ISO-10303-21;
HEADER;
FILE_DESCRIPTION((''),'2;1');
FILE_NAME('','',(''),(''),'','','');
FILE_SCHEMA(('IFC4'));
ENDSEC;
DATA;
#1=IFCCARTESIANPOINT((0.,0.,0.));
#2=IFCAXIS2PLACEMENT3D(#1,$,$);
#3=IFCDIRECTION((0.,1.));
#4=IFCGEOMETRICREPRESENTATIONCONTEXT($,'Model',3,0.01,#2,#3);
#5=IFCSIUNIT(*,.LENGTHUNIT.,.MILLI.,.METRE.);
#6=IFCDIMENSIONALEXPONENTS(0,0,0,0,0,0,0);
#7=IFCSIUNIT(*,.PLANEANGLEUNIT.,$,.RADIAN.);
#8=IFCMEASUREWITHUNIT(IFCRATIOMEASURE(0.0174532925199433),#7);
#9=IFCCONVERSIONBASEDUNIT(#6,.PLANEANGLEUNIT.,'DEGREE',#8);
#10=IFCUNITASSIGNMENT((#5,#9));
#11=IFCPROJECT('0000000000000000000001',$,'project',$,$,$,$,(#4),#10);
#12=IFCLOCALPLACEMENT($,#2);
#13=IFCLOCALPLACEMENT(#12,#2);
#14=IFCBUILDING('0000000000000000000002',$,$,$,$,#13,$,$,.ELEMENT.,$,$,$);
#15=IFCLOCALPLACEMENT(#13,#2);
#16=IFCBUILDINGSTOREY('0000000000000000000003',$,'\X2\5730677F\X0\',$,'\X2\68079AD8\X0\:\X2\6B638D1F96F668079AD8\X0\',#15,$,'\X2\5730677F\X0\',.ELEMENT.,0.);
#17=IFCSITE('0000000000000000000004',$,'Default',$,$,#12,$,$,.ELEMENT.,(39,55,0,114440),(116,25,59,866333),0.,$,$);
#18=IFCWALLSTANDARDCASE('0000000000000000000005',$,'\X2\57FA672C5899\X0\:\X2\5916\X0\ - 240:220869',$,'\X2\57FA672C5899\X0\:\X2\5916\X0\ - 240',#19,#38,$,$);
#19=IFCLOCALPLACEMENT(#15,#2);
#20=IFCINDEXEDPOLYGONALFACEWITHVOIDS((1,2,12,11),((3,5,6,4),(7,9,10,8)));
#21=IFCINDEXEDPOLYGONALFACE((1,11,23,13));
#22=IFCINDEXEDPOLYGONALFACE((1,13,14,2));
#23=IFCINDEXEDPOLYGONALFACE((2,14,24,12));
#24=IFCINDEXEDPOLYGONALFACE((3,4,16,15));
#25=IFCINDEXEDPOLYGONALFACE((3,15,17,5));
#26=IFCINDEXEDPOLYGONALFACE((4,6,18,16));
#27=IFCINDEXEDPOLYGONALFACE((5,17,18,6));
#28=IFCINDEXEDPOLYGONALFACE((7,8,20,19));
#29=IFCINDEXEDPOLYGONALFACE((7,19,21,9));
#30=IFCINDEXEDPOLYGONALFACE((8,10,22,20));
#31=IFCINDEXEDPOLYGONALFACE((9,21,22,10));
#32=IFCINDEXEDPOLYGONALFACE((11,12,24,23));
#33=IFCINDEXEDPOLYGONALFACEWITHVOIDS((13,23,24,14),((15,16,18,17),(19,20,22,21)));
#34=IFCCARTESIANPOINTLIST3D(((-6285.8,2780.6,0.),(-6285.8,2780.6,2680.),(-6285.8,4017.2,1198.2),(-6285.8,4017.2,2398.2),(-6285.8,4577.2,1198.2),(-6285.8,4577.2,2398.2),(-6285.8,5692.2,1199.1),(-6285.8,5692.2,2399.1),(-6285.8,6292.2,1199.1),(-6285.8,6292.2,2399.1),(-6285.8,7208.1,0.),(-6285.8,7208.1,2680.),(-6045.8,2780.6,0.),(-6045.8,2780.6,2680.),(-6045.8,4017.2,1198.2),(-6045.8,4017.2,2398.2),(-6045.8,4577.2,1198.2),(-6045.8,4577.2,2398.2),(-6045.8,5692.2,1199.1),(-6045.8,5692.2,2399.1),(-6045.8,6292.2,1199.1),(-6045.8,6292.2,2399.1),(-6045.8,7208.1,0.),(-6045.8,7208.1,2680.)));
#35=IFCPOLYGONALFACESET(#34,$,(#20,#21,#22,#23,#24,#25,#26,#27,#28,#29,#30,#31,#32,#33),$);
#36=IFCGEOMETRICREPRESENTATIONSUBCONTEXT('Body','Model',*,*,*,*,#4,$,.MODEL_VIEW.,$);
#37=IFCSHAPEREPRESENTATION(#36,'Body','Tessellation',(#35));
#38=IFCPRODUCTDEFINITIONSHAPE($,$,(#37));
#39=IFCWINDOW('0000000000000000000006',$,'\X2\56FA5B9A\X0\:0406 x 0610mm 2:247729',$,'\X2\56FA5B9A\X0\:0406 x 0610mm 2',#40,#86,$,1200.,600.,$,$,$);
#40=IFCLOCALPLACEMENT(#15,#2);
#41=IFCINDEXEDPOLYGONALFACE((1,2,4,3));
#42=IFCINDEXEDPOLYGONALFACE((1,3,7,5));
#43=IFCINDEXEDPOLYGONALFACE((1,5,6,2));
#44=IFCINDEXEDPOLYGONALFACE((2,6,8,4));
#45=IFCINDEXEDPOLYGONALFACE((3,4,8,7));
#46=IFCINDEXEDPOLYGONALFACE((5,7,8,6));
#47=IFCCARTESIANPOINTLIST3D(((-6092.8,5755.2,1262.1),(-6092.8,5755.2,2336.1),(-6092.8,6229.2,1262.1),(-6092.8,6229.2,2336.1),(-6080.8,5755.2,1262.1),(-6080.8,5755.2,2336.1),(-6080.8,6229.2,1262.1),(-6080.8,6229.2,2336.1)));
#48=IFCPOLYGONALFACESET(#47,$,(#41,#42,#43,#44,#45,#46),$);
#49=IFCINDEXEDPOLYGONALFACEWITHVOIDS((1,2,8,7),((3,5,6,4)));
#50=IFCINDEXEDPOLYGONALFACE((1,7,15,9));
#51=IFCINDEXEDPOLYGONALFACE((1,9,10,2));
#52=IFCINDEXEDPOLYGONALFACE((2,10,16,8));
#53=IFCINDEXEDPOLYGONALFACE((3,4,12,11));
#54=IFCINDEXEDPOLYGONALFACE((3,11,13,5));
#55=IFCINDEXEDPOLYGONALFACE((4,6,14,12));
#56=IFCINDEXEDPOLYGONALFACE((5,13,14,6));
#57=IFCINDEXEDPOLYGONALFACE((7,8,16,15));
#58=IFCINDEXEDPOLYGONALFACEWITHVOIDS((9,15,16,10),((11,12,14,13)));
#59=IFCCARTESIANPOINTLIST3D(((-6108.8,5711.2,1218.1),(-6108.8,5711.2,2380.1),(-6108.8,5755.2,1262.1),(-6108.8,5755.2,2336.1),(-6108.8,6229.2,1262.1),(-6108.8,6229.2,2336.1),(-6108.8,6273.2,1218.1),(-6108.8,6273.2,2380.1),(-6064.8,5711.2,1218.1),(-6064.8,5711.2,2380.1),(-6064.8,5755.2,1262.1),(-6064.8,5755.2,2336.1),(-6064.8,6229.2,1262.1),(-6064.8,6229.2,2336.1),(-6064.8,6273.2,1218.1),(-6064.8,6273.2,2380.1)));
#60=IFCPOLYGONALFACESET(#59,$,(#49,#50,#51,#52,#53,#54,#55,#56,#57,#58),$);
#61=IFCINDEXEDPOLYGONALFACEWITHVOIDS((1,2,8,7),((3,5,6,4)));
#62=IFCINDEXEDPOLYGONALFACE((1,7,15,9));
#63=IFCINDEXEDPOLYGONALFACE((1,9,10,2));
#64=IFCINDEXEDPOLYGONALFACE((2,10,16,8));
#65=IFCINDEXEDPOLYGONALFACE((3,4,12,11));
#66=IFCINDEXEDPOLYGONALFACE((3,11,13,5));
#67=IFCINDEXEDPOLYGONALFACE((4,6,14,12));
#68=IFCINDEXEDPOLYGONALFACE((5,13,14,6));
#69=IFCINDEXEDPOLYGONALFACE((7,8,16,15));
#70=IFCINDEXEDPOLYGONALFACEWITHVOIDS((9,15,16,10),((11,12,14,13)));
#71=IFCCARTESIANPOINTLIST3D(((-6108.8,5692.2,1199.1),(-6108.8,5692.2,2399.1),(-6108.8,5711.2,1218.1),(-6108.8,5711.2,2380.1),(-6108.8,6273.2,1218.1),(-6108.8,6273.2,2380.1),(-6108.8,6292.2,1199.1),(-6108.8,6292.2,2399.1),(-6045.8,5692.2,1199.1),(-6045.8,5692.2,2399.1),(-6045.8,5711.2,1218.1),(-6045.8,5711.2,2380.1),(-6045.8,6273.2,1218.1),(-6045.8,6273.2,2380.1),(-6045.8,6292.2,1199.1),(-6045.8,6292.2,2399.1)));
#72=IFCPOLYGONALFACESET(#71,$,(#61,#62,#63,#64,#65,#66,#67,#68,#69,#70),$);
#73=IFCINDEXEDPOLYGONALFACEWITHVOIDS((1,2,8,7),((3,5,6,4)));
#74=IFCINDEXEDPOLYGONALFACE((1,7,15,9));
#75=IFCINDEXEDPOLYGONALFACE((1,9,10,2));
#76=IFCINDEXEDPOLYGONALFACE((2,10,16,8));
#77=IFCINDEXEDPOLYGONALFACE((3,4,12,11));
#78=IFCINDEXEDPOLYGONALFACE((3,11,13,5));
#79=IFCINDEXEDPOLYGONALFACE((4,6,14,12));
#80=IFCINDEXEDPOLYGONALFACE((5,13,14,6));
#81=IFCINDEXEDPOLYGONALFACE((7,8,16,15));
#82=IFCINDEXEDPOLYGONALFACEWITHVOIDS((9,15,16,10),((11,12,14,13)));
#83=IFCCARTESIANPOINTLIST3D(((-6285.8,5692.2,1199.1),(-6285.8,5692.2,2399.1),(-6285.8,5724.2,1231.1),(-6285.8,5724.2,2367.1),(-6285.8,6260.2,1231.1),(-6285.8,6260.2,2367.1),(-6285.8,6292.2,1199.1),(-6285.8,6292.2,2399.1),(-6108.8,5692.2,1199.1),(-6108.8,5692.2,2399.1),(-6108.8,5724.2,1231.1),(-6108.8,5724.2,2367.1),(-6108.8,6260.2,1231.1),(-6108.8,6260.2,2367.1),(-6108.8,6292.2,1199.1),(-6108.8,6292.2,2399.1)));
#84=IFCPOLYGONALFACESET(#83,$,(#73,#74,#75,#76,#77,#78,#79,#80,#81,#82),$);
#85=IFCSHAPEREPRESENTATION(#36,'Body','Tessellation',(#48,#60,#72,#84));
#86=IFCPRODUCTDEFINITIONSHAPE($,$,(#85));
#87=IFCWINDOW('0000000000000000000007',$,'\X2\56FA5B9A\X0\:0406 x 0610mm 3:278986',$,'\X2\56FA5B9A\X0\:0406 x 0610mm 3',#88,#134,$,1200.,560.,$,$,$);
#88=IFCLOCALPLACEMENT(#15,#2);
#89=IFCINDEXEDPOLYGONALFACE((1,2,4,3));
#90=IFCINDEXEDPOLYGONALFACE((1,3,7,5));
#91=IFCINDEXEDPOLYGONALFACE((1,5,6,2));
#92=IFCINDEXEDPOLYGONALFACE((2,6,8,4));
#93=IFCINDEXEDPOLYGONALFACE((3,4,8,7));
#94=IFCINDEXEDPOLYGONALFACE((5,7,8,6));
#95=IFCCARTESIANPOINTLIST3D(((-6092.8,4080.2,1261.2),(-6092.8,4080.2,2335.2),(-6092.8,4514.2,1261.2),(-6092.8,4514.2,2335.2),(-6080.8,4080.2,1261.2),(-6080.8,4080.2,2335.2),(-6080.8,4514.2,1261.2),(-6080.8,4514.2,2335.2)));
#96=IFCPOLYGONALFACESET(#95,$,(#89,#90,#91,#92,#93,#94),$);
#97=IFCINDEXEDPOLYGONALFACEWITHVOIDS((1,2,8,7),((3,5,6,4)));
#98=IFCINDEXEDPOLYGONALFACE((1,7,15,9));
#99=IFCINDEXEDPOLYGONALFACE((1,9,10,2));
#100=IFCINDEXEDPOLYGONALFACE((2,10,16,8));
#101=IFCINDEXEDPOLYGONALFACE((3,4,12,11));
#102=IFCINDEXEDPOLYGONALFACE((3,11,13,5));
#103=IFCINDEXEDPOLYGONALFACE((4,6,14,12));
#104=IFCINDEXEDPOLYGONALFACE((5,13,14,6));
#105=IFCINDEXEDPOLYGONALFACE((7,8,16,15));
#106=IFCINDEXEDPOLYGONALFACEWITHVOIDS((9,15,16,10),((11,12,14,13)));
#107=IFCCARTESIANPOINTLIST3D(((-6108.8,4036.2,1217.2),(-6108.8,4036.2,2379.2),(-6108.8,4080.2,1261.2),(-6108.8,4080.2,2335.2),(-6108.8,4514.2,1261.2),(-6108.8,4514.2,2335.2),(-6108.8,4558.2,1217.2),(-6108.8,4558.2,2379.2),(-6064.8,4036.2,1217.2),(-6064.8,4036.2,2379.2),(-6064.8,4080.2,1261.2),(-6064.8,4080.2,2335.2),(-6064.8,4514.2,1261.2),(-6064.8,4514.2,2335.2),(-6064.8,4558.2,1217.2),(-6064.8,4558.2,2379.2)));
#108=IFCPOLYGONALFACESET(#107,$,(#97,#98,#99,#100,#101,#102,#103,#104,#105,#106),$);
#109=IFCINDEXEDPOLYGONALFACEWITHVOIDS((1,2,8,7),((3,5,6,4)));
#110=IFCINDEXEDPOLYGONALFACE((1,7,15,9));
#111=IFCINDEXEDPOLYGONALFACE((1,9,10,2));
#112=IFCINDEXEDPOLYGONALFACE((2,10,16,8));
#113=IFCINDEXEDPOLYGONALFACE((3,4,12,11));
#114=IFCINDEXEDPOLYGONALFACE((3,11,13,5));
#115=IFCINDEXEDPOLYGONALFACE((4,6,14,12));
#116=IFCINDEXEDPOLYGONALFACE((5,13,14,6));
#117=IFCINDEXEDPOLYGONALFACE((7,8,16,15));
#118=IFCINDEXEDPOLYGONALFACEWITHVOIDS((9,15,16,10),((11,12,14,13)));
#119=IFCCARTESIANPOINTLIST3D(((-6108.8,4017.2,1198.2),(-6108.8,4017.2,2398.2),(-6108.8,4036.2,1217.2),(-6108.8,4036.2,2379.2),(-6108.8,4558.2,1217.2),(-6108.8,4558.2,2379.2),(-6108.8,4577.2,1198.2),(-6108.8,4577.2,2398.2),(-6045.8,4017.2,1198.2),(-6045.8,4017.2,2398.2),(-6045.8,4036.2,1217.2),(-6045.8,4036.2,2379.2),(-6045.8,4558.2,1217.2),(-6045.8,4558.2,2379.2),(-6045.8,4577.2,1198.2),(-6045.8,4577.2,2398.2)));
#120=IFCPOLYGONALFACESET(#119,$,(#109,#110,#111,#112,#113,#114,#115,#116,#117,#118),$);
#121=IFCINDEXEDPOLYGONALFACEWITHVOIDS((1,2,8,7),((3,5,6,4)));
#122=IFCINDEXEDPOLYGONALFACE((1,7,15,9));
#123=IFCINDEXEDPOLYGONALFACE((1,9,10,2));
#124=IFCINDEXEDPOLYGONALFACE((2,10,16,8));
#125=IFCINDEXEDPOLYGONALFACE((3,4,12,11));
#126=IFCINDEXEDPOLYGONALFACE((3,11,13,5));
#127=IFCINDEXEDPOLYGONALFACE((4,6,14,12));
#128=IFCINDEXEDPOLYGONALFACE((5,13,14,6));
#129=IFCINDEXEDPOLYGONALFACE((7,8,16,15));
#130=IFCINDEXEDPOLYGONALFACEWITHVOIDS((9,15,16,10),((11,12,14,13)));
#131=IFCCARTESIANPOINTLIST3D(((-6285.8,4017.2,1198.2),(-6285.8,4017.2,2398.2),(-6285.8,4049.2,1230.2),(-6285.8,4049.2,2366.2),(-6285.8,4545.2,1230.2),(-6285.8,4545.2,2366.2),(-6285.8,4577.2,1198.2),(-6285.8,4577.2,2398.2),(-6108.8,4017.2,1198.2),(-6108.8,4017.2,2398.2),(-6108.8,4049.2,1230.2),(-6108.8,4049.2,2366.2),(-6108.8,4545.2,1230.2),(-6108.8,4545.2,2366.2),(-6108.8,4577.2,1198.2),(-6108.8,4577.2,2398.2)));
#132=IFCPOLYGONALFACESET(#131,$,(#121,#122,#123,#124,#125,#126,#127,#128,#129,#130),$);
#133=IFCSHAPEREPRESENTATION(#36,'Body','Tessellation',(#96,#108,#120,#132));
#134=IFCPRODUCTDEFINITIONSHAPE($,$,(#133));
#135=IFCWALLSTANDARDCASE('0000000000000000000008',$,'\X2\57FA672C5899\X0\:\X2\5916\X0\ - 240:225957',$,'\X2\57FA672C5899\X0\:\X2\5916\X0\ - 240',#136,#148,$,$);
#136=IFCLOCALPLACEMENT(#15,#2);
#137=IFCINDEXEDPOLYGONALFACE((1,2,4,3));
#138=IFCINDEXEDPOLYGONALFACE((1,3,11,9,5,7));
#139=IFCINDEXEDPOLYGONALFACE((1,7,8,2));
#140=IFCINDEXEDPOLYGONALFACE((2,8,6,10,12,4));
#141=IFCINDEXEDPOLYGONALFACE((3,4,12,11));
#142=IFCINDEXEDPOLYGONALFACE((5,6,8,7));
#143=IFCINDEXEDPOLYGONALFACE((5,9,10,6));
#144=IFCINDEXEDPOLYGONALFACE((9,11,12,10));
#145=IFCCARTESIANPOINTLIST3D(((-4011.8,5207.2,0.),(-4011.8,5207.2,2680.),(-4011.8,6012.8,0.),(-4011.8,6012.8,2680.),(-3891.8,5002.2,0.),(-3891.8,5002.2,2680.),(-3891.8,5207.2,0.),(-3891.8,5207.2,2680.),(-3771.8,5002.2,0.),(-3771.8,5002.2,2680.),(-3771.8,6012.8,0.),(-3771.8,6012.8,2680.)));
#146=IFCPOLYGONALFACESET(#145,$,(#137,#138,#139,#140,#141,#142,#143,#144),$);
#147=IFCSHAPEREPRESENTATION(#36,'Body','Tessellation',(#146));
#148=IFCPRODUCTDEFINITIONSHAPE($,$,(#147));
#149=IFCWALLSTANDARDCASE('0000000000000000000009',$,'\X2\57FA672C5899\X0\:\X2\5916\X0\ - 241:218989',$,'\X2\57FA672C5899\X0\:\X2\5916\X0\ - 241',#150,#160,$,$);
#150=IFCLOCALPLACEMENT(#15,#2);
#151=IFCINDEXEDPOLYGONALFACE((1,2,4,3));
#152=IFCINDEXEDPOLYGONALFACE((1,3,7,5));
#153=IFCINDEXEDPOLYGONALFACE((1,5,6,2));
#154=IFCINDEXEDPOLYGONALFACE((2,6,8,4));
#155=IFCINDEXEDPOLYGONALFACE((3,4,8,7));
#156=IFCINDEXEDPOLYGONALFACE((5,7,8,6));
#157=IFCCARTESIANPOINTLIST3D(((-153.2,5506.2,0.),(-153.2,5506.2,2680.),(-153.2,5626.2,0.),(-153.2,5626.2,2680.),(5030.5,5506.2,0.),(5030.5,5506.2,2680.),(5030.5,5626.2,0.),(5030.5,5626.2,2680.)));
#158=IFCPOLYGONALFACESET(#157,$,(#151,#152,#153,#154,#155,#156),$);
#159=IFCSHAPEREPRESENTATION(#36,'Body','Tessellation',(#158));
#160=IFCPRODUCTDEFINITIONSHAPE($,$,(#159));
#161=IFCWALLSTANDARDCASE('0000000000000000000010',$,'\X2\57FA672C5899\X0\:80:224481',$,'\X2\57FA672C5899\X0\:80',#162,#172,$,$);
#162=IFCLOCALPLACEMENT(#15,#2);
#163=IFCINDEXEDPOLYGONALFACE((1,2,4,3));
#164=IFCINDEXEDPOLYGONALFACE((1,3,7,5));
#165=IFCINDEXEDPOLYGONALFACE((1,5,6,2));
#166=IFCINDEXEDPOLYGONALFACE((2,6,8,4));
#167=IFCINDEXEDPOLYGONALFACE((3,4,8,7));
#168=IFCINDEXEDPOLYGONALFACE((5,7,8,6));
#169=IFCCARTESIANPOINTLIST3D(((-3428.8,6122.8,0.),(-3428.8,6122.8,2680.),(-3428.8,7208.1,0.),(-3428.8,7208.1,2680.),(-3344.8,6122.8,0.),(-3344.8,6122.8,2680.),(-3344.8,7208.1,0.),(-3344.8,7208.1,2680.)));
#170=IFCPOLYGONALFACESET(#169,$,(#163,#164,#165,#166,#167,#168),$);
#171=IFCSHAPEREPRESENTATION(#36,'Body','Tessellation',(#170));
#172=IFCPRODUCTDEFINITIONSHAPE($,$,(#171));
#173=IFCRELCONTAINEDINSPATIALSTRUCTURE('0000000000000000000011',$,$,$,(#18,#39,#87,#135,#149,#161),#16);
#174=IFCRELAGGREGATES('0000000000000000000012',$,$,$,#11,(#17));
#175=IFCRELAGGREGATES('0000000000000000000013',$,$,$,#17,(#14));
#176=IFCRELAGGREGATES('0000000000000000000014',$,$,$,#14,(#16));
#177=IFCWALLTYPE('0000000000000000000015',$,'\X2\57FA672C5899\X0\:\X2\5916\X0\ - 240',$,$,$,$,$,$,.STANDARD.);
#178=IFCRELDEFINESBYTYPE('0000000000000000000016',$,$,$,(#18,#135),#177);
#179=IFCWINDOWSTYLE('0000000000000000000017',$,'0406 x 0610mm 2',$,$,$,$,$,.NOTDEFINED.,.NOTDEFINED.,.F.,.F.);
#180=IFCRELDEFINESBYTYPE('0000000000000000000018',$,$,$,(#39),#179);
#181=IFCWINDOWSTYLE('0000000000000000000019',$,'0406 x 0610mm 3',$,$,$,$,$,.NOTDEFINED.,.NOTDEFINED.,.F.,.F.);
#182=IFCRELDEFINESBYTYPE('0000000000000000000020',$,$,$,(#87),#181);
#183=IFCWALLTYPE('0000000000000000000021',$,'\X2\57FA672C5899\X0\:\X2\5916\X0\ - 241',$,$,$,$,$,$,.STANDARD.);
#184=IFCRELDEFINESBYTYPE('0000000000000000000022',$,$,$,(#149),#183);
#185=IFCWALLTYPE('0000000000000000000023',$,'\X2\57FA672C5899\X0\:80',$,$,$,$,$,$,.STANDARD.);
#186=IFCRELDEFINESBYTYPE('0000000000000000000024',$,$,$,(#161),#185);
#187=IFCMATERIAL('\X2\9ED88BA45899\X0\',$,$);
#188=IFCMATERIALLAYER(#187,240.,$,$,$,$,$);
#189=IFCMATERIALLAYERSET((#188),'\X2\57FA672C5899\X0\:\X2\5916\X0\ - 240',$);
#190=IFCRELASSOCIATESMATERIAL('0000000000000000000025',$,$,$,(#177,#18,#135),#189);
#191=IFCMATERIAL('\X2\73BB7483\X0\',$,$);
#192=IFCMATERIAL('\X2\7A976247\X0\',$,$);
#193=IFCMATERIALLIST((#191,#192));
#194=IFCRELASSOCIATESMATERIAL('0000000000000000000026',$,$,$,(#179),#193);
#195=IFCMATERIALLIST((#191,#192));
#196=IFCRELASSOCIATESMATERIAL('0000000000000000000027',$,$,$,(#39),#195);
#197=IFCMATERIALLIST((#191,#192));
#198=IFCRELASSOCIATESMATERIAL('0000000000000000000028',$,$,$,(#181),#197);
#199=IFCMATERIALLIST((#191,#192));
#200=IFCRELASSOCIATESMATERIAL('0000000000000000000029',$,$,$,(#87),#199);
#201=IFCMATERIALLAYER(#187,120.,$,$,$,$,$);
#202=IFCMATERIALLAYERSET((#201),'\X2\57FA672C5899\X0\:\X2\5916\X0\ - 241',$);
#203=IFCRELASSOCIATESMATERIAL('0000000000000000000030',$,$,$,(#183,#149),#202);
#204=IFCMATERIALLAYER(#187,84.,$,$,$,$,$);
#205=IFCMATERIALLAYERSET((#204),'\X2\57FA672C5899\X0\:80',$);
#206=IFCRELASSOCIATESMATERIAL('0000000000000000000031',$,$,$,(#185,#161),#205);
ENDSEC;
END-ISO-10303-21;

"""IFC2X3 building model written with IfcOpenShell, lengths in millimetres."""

from ifc_helpers import new_model, entity, si_unit, converted_unit, direction, frame, frame_2d, origin, place, context, subcontext, project, spatial, polyline, rectangle, outline, extrude, source, transform, mapped, material, material_list, layer, layer_set, layer_usage, type_object, type_shapes, element, fill, save


model = new_model("IFC2X3")

# Units and contexts
model_context = context("Model", 3, precision=0.01, world=origin(), true_north=direction((0.0, 1.0)))
body_context = subcontext(model_context, "Body", "Model", "MODEL_VIEW")
ifc_project = project(units=[si_unit("LENGTHUNIT", "METRE", prefix="MILLI"), converted_unit("PLANEANGLEUNIT", "DEGREE", entity("IfcRatioMeasure", 0.0174532925199433), si_unit("PLANEANGLEUNIT", "RADIAN"), dimensions=[0, 0, 0, 0, 0, 0, 0])], contexts=[model_context])

# Site, building, storey
site_placement = place(None, origin())
site = spatial("IfcSite", under=ifc_project, at=site_placement, Name="Default", CompositionType="ELEMENT", RefLatitude=(39, 55, 0, 114440), RefLongitude=(116, 25, 59, 866333), RefElevation=0.0)
building_placement = place(site_placement, origin())
building = spatial("IfcBuilding", under=site, at=building_placement, CompositionType="ELEMENT")
storey_placement = place(building_placement, origin())
storey = spatial("IfcBuildingStorey", under=building, at=storey_placement, Name="地板", ObjectType="标高:正负零标高", LongName="地板", CompositionType="ELEMENT", Elevation=0.0)

# Shared definitions
ifc_material_1 = material(Name="默认墙")
ifc_layer_1 = layer(ifc_material_1, 240.0)
ifc_layer_set_1 = layer_set([ifc_layer_1], Name="基本墙:外 - 240")
wall_type_1 = type_object("IfcWallType", Name="基本墙:外 - 240", PredefinedType="STANDARD", material=ifc_layer_set_1)
ifc_material_2 = material(Name="玻璃")
ifc_material_3 = material(Name="窗扇")

# Wall, openings, windows
ifc_layer_usage_1 = layer_usage(ifc_layer_set_1, "AXIS2", "NEGATIVE", 120.0)
wall_1_placement = place(storey_placement, frame((-6165.8, 7208.1, 0.0), z_axis=(0.0, 0.0, 1.0), x_axis=(0.0, -1.0, 0.0)))
wall_1 = element("IfcWallStandardCase", 1, at=wall_1_placement, inside=storey, type_object=wall_type_1, material=ifc_layer_usage_1, Name="基本墙:外 - 240:220869", ObjectType="基本墙:外 - 240", context=body_context, shape_type="SweptSolid", body=[
    extrude(rectangle(XDim=4427.5, YDim=240.0, at=frame_2d((2213.8, 0.0), x_axis=(-1.0, 0.0))), origin(), (0.0, 0.0, 1.0), 2680.0),
])
opening_1_placement = place(wall_1_placement, frame((915.9, -120.0, 1199.1)))
opening_1 = element("IfcOpeningElement", 2, at=opening_1_placement, cuts=wall_1, ObjectType="Opening", context=body_context, shape_type="SweptSolid", body=[
    extrude(rectangle(XDim=1200.0, YDim=600.0, at=frame_2d((600.0, 300.0), x_axis=(1.0, 0.0))), frame((0.0, 0.0, 0.0), z_axis=(0.0, 1.0, 0.0), x_axis=(0.0, 0.0, 1.0)), (0.0, 0.0, 1.0), 240.0),
])
opening_2_placement = place(wall_1_placement, frame((2630.9, -120.0, 1198.2)))
opening_2 = element("IfcOpeningElement", 3, at=opening_2_placement, cuts=wall_1, ObjectType="Opening", context=body_context, shape_type="SweptSolid", body=[
    extrude(rectangle(XDim=1200.0, YDim=560.0, at=frame_2d((600.0, 280.0), x_axis=(1.0, 0.0))), frame((0.0, 0.0, 0.0), z_axis=(0.0, 1.0, 0.0), x_axis=(0.0, 0.0, 1.0)), (0.0, 0.0, 1.0), 240.0),
])
ifc_material_list_1 = material_list([ifc_material_2, ifc_material_3])
ifc_material_list_2 = material_list([ifc_material_2, ifc_material_3])
window_style_1 = type_object("IfcWindowStyle", Name="0406 x 0610mm 2", ConstructionType="NOTDEFINED", OperationType="NOTDEFINED", ParameterTakesPrecedence=False, Sizeable=False, material=ifc_material_list_2)
shared_shape_1 = source(origin(), body_context, "Body", "SweptSolid", [
    extrude(rectangle(XDim=12.0, YDim=474.0, at=frame_2d((0.0, 0.0), x_axis=(1.0, 0.0))), frame((300.0, 199.0, 63.0), z_axis=(0.0, 0.0, 1.0), x_axis=(0.0, -1.0, 0.0)), (0.0, 0.0, 1.0), 1074.0),
    extrude(outline(polyline([(-281.0, -581.0), (281.0, -581.0), (281.0, 581.0), (-281.0, 581.0), (-281.0, -581.0)]), holes=[polyline([(-237.0, -537.0), (-237.0, 537.0), (237.0, 537.0), (237.0, -537.0), (-237.0, -537.0)])]), frame((300.0, 177.0, 600.0), z_axis=(0.0, 1.0, 0.0), x_axis=(1.0, 0.0, 0.0)), (0.0, 0.0, 1.0), 44.0),
    extrude(outline(polyline([(-300.0, -600.0), (300.0, -600.0), (300.0, 600.0), (-300.0, 600.0), (-300.0, -600.0)]), holes=[polyline([(-281.0, -581.0), (-281.0, 581.0), (281.0, 581.0), (281.0, -581.0), (-281.0, -581.0)])]), frame((300.0, 177.0, 600.0), z_axis=(0.0, 1.0, 0.0), x_axis=(1.0, 0.0, 0.0)), (0.0, 0.0, 1.0), 63.0),
    extrude(outline(polyline([(-300.0, -600.0), (300.0, -600.0), (300.0, 600.0), (-300.0, 600.0), (-300.0, -600.0)]), holes=[polyline([(-268.0, -568.0), (-268.0, 568.0), (268.0, 568.0), (268.0, -568.0), (-268.0, -568.0)])]), frame((300.0, 0.0, 600.0), z_axis=(0.0, 1.0, 0.0), x_axis=(1.0, 0.0, 0.0)), (0.0, 0.0, 1.0), 177.0),
])
type_shapes(window_style_1, [shared_shape_1])
window_1_placement = place(opening_1_placement, origin())
window_1 = element("IfcWindow", 4, at=window_1_placement, inside=storey, type_object=window_style_1, material=ifc_material_list_1, Name="固定:0406 x 0610mm 2:247729", ObjectType="固定:0406 x 0610mm 2", OverallHeight=1200.0, OverallWidth=600.0, context=body_context, shape_type="MappedRepresentation", body=[
    mapped(shared_shape_1, transform((0.0, 0.0, 0.0), scale=1.0)),
])
fill(opening_1, window_1)
ifc_material_list_3 = material_list([ifc_material_2, ifc_material_3])
ifc_material_list_4 = material_list([ifc_material_2, ifc_material_3])
window_style_2 = type_object("IfcWindowStyle", Name="0406 x 0610mm 3", ConstructionType="NOTDEFINED", OperationType="NOTDEFINED", ParameterTakesPrecedence=False, Sizeable=False, material=ifc_material_list_4)
shared_shape_2 = source(origin(), body_context, "Body", "SweptSolid", [
    extrude(rectangle(XDim=12.0, YDim=434.0, at=frame_2d((0.0, 0.0), x_axis=(1.0, 0.0))), frame((280.0, 199.0, 63.0), z_axis=(0.0, 0.0, 1.0), x_axis=(0.0, -1.0, 0.0)), (0.0, 0.0, 1.0), 1074.0),
    extrude(outline(polyline([(-261.0, -581.0), (261.0, -581.0), (261.0, 581.0), (-261.0, 581.0), (-261.0, -581.0)]), holes=[polyline([(-217.0, -537.0), (-217.0, 537.0), (217.0, 537.0), (217.0, -537.0), (-217.0, -537.0)])]), frame((280.0, 177.0, 600.0), z_axis=(0.0, 1.0, 0.0), x_axis=(1.0, 0.0, 0.0)), (0.0, 0.0, 1.0), 44.0),
    extrude(outline(polyline([(-280.0, -600.0), (280.0, -600.0), (280.0, 600.0), (-280.0, 600.0), (-280.0, -600.0)]), holes=[polyline([(-261.0, -581.0), (-261.0, 581.0), (261.0, 581.0), (261.0, -581.0), (-261.0, -581.0)])]), frame((280.0, 177.0, 600.0), z_axis=(0.0, 1.0, 0.0), x_axis=(1.0, 0.0, 0.0)), (0.0, 0.0, 1.0), 63.0),
    extrude(outline(polyline([(-280.0, -600.0), (280.0, -600.0), (280.0, 600.0), (-280.0, 600.0), (-280.0, -600.0)]), holes=[polyline([(-248.0, -568.0), (-248.0, 568.0), (248.0, 568.0), (248.0, -568.0), (-248.0, -568.0)])]), frame((280.0, 0.0, 600.0), z_axis=(0.0, 1.0, 0.0), x_axis=(1.0, 0.0, 0.0)), (0.0, 0.0, 1.0), 177.0),
])
type_shapes(window_style_2, [shared_shape_2])
window_2_placement = place(opening_2_placement, origin())
window_2 = element("IfcWindow", 5, at=window_2_placement, inside=storey, type_object=window_style_2, material=ifc_material_list_3, Name="固定:0406 x 0610mm 3:278986", ObjectType="固定:0406 x 0610mm 3", OverallHeight=1200.0, OverallWidth=560.0, context=body_context, shape_type="MappedRepresentation", body=[
    mapped(shared_shape_2, transform((0.0, 0.0, 0.0), scale=1.0)),
])
fill(opening_2, window_2)

# Walls
ifc_layer_usage_2 = layer_usage(ifc_layer_set_1, "AXIS2", "NEGATIVE", 120.0)
wall_2_placement = place(storey_placement, frame((-3891.8, 6012.8, 0.0), z_axis=(0.0, 0.0, 1.0), x_axis=(0.0, -1.0, 0.0)))
element("IfcWallStandardCase", 6, at=wall_2_placement, inside=storey, type_object=wall_type_1, material=ifc_layer_usage_2, Name="基本墙:外 - 240:225957", ObjectType="基本墙:外 - 240", context=body_context, shape_type="SweptSolid", body=[
    extrude(outline(polyline([(805.6, -120.0), (805.6, 0.0), (1010.6, 0.0), (1010.6, 120.0), (0.0, 120.0), (0.0, -120.0), (805.6, -120.0)])), origin(), (0.0, 0.0, 1.0), 2680.0),
])
ifc_layer_2 = layer(ifc_material_1, 120.0)
ifc_layer_set_2 = layer_set([ifc_layer_2], Name="基本墙:外 - 241")
ifc_layer_usage_3 = layer_usage(ifc_layer_set_2, "AXIS2", "NEGATIVE", 60.0)
wall_type_2 = type_object("IfcWallType", Name="基本墙:外 - 241", PredefinedType="STANDARD", material=ifc_layer_set_2)
wall_3_placement = place(storey_placement, frame((5030.5, 5566.2, 0.0), z_axis=(0.0, 0.0, 1.0), x_axis=(-1.0, 0.0, 0.0)))
element("IfcWallStandardCase", 7, at=wall_3_placement, inside=storey, type_object=wall_type_2, material=ifc_layer_usage_3, Name="基本墙:外 - 241:218989", ObjectType="基本墙:外 - 241", context=body_context, shape_type="SweptSolid", body=[
    extrude(rectangle(XDim=5183.7, YDim=120.0, at=frame_2d((2591.8, 0.0), x_axis=(-1.0, 0.0))), origin(), (0.0, 0.0, 1.0), 2680.0),
])
ifc_layer_3 = layer(ifc_material_1, 84.0)
ifc_layer_set_3 = layer_set([ifc_layer_3], Name="基本墙:80")
ifc_layer_usage_4 = layer_usage(ifc_layer_set_3, "AXIS2", "NEGATIVE", 42.0)
wall_type_3 = type_object("IfcWallType", Name="基本墙:80", PredefinedType="STANDARD", material=ifc_layer_set_3)
wall_4_placement = place(storey_placement, frame((-3386.8, 7208.1, 0.0), z_axis=(0.0, 0.0, 1.0), x_axis=(0.0, -1.0, 0.0)))
element("IfcWallStandardCase", 8, at=wall_4_placement, inside=storey, type_object=wall_type_3, material=ifc_layer_usage_4, Name="基本墙:80:224481", ObjectType="基本墙:80", context=body_context, shape_type="SweptSolid", body=[
    extrude(rectangle(XDim=1085.3, YDim=84.0, at=frame_2d((542.6, 0.0), x_axis=(-1.0, 0.0))), origin(), (0.0, 0.0, 1.0), 2680.0),
])

save(model, "model.ifc")
